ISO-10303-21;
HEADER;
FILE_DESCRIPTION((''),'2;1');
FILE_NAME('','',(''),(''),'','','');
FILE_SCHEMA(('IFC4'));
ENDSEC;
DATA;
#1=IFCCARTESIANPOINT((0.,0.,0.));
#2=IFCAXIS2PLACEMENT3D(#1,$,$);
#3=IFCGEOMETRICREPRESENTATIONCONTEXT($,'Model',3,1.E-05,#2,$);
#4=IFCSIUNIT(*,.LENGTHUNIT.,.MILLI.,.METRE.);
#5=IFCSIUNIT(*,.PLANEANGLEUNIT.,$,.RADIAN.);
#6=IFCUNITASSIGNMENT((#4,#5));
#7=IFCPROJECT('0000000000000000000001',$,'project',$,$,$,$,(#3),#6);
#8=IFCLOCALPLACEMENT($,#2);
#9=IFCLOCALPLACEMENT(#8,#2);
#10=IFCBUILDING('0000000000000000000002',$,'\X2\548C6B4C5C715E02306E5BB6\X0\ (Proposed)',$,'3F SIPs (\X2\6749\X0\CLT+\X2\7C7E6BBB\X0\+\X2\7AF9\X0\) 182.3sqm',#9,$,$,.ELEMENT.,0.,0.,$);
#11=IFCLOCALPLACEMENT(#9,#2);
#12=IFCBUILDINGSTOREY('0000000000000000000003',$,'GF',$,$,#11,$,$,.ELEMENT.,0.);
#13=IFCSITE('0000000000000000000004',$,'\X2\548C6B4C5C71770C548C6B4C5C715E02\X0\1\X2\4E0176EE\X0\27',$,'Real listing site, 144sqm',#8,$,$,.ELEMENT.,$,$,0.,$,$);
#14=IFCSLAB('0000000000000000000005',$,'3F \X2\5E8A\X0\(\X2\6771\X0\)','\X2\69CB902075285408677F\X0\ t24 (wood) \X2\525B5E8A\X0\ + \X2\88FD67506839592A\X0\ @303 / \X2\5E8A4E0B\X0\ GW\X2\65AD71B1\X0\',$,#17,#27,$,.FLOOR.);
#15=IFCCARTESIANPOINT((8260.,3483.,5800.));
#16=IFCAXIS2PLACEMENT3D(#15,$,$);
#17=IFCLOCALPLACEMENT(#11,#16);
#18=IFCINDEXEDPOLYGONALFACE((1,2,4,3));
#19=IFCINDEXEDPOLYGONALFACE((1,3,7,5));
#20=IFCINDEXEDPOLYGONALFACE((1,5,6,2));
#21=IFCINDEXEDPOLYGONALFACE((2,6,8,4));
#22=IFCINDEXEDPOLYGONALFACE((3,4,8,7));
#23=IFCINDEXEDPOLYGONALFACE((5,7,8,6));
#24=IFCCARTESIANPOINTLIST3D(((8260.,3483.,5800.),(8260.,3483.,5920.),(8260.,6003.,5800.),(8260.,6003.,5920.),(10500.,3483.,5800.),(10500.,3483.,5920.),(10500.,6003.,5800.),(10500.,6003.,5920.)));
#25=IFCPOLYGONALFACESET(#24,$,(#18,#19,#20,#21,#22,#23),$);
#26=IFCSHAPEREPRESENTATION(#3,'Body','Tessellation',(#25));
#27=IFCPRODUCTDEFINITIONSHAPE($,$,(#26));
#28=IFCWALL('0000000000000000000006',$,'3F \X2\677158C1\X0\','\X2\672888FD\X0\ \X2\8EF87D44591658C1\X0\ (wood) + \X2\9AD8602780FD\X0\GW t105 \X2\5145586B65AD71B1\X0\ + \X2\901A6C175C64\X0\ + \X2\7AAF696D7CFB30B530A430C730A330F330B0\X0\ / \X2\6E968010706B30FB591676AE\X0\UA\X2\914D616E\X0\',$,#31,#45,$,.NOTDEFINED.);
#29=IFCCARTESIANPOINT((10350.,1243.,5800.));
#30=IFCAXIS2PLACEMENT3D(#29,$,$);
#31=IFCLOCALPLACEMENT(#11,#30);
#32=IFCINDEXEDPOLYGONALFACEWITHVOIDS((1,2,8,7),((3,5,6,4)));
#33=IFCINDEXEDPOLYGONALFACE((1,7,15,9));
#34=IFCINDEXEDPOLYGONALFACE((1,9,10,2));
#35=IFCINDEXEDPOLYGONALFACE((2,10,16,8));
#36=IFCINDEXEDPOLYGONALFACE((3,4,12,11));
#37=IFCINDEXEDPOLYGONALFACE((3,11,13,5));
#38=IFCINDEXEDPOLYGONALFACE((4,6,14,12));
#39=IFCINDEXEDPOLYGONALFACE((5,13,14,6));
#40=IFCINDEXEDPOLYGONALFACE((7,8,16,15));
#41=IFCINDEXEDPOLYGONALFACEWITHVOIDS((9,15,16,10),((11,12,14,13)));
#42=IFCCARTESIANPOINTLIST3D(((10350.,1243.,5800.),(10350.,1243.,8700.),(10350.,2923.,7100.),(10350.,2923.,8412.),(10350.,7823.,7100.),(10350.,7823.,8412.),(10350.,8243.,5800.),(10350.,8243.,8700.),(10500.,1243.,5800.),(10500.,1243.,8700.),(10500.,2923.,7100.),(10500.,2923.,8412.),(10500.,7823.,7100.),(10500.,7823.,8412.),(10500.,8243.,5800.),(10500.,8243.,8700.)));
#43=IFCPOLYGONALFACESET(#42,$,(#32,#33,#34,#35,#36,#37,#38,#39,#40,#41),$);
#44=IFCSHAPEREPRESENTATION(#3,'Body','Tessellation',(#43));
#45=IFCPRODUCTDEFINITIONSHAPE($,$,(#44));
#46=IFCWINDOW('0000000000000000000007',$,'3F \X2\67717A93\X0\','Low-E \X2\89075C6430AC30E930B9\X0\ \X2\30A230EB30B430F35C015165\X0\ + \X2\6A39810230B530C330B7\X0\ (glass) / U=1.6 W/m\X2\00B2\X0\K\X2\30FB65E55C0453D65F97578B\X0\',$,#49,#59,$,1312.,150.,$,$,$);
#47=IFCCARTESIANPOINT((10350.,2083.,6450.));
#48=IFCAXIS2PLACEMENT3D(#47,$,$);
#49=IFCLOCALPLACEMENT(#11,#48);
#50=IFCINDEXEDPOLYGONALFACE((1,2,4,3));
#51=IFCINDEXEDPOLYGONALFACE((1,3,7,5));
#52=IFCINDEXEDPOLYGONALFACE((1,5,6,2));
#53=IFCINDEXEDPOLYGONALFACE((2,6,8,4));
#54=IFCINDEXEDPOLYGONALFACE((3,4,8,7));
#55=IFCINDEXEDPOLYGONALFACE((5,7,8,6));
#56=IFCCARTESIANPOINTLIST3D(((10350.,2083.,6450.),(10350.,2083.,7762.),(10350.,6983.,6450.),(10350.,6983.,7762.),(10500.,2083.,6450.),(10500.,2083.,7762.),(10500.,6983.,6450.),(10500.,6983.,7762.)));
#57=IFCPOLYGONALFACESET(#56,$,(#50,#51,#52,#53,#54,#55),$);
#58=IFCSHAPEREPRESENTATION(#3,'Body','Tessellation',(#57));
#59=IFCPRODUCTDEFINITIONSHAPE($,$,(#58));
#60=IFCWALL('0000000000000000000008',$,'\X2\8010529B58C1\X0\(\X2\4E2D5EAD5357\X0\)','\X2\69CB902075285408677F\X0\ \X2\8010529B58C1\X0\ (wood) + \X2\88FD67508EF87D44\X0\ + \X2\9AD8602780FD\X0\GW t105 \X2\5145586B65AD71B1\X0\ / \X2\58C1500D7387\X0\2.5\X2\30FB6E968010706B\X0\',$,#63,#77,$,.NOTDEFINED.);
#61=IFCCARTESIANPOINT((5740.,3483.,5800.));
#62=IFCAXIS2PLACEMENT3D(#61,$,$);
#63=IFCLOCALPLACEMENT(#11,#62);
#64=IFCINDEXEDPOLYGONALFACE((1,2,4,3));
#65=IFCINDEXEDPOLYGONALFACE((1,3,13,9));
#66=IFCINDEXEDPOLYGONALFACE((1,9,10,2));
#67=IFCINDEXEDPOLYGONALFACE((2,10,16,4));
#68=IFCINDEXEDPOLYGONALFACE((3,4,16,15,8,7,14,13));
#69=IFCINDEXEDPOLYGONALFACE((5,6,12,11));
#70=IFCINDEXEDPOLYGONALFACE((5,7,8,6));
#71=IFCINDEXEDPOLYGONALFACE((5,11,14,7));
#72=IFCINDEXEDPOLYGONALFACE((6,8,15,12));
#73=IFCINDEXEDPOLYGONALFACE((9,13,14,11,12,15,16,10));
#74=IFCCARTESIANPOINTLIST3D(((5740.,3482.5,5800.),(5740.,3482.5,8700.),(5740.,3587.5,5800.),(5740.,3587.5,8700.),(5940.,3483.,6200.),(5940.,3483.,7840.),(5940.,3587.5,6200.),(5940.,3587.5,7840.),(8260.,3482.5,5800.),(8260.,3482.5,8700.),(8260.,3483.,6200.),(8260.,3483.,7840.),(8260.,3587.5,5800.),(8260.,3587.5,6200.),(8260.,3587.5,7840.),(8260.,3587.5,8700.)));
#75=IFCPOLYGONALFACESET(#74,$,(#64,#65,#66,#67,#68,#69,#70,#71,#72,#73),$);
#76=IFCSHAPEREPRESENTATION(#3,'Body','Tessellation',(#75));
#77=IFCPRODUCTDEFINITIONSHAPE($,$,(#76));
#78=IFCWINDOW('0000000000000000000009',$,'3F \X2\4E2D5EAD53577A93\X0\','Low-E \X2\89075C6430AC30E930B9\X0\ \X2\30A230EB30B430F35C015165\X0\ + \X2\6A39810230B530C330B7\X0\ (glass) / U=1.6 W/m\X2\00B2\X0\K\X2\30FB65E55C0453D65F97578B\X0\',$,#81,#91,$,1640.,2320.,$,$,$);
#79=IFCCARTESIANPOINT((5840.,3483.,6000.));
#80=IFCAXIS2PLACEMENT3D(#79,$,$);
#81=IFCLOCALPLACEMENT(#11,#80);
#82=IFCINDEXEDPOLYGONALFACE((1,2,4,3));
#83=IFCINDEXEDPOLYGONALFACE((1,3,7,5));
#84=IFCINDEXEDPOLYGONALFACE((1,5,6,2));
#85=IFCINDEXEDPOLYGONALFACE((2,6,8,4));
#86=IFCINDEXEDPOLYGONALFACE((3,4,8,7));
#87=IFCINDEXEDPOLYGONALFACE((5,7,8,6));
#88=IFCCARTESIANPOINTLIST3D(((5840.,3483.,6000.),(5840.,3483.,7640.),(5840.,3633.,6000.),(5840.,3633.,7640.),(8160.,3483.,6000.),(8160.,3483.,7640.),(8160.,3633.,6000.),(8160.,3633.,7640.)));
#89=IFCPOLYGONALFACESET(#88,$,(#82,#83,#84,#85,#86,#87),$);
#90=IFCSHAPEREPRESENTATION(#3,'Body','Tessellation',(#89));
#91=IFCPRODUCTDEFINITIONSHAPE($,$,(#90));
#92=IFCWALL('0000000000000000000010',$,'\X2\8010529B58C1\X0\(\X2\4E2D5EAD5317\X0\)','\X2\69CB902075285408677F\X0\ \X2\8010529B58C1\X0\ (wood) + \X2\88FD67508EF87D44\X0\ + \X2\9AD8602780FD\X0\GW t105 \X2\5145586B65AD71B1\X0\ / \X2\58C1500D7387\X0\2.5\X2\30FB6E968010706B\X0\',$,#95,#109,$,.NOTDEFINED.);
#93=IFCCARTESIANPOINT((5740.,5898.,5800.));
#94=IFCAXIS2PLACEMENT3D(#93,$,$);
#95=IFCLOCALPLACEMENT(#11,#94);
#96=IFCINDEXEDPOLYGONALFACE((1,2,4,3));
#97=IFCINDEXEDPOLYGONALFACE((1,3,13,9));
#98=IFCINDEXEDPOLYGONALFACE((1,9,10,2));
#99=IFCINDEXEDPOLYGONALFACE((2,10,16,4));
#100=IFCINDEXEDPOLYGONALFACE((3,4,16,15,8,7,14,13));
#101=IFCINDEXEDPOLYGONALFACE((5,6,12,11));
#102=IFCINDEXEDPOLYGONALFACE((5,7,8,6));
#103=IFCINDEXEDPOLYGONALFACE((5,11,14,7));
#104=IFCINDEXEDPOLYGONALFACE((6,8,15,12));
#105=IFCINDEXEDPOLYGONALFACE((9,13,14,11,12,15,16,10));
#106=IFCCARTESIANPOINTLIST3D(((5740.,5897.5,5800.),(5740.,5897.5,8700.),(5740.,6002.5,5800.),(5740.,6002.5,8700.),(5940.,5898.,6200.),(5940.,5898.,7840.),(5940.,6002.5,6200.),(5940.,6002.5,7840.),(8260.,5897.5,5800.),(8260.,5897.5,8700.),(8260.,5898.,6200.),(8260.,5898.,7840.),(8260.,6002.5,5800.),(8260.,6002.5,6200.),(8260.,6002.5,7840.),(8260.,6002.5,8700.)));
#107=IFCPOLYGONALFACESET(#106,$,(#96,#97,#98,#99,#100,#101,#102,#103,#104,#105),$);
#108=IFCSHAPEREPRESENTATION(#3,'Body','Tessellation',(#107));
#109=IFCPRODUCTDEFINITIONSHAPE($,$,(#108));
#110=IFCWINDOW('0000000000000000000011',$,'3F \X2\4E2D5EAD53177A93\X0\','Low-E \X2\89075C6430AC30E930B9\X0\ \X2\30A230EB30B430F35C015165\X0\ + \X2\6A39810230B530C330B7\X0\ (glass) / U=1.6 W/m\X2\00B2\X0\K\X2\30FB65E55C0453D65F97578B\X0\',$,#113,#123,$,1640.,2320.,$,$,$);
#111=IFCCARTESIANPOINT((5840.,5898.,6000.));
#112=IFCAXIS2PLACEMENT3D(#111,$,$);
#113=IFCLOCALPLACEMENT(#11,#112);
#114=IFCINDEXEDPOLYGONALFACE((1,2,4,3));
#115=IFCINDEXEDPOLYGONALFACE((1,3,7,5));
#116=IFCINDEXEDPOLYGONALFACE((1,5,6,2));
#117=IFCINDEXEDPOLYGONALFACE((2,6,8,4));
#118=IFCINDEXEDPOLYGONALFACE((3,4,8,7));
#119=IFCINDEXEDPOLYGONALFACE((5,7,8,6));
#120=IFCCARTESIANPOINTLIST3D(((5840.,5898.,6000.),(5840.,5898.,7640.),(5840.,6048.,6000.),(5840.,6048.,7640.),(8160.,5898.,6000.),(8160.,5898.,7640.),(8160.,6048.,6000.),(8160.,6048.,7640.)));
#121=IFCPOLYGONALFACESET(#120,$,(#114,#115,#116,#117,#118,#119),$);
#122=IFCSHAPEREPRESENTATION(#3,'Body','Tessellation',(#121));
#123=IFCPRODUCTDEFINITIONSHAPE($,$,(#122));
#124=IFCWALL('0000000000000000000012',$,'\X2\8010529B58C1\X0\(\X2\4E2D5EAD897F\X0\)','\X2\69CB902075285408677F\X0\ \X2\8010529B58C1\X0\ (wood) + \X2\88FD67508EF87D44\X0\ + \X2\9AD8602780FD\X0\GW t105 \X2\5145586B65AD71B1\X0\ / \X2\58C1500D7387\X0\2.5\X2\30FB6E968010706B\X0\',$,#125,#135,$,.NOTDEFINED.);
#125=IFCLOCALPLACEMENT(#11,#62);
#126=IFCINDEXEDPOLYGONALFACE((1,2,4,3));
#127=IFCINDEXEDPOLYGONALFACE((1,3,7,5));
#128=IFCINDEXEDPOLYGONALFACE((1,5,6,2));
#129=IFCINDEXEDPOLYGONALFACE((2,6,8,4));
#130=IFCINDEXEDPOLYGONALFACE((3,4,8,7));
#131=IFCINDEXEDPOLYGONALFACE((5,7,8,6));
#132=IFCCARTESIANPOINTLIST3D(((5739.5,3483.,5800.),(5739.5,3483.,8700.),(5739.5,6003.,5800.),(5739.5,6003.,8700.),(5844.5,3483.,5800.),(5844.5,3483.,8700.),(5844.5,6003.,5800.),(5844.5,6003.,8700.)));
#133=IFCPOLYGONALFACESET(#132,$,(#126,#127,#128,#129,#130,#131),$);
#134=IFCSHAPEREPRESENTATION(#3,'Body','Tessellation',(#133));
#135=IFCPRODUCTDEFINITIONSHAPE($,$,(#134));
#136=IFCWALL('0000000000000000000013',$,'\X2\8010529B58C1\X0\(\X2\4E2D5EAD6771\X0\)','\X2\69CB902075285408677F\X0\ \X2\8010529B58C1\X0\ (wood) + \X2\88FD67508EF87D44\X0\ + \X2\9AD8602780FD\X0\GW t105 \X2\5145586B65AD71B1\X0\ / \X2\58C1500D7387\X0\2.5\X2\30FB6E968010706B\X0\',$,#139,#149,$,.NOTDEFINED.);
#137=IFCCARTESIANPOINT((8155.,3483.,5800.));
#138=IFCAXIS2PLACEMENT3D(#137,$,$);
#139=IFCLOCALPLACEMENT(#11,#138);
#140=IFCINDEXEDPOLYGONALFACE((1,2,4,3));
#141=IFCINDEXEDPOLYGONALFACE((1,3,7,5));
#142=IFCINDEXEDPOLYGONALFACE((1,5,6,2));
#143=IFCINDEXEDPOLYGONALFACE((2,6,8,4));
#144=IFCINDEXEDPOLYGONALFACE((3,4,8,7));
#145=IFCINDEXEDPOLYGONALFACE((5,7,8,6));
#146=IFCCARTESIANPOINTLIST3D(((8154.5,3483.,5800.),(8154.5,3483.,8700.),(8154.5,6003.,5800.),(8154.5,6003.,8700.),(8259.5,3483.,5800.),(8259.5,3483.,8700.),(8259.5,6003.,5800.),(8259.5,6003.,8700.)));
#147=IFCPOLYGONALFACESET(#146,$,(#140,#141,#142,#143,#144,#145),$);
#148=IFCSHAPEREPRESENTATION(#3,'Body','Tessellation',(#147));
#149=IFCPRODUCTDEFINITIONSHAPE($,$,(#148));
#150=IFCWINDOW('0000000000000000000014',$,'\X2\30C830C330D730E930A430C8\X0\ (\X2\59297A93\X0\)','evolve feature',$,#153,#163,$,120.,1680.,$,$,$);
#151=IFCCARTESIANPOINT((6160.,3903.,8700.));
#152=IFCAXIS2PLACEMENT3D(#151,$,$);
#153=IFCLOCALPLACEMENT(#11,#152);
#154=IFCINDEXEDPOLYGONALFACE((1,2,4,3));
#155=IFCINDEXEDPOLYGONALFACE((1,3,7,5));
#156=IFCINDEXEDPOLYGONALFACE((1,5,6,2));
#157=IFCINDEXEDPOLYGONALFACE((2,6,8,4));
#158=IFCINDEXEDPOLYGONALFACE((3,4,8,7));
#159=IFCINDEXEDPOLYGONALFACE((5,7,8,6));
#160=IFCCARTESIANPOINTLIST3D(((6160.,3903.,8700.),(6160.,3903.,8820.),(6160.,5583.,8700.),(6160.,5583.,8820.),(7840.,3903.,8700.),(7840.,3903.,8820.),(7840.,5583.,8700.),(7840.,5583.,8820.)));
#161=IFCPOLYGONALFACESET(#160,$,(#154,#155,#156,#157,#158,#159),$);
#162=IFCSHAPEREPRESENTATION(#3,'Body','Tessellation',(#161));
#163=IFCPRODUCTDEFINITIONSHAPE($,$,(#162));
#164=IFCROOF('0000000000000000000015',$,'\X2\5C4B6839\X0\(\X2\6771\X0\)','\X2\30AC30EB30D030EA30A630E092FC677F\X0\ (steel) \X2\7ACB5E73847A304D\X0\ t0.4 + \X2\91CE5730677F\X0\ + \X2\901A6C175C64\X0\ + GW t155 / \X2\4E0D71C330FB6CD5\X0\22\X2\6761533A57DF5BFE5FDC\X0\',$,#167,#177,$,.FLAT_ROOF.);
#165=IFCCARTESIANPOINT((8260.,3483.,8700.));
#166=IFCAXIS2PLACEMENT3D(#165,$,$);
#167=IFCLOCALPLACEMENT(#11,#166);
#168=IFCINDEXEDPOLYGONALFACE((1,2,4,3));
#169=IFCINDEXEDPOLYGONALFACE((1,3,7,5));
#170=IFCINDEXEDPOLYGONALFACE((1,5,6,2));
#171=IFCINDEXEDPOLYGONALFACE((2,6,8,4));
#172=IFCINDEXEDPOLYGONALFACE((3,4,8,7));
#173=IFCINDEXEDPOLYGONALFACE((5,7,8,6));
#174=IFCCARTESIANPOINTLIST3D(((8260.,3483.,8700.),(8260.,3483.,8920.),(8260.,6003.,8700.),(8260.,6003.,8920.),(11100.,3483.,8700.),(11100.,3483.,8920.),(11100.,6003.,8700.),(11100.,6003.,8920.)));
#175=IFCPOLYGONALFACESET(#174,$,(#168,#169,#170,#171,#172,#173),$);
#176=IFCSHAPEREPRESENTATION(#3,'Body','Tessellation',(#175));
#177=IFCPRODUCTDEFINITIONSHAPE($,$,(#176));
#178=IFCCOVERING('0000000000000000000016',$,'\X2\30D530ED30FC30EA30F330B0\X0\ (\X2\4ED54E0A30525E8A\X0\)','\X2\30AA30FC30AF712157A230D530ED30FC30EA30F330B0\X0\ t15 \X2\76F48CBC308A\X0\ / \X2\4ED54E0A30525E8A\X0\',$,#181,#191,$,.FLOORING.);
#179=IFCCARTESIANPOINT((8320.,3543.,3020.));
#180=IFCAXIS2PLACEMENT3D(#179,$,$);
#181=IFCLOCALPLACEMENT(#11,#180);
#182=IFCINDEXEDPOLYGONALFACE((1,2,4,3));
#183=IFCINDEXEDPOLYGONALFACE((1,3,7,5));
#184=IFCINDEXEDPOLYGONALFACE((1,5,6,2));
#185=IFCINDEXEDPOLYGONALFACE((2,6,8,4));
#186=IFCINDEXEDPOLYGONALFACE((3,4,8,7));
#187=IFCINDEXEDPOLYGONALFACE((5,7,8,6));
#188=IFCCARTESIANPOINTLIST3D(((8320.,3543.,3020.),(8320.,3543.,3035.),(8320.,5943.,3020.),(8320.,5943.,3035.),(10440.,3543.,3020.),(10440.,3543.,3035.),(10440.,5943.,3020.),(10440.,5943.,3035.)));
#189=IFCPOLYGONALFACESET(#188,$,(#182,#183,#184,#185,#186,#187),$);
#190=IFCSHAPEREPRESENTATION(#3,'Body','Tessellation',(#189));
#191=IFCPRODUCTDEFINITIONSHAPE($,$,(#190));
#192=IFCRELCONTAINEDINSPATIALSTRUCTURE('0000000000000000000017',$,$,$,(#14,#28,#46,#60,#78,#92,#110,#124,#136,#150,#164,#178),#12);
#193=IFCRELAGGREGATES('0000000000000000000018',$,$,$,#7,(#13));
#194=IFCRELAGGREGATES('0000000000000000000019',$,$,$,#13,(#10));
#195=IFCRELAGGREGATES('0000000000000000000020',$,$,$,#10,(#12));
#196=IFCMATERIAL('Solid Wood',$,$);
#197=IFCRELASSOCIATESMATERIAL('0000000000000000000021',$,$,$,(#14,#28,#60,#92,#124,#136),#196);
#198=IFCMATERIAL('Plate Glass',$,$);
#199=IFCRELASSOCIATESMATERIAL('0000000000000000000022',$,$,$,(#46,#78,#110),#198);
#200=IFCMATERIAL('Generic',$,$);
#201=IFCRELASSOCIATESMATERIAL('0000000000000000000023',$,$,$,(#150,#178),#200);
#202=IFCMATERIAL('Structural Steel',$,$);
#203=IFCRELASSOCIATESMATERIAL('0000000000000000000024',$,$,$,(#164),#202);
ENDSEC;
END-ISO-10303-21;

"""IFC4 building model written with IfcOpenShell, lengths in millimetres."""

from ifc_helpers import new_model, si_unit, frame, frame_2d, origin, place, context, project, spatial, rectangle, extrude, material, element, fill, save


model = new_model("IFC4")

# Units and contexts
model_context = context("Model", 3, precision=1e-05, world=origin())
ifc_project = project(units=[si_unit("LENGTHUNIT", "METRE", prefix="MILLI"), si_unit("PLANEANGLEUNIT", "RADIAN")], contexts=[model_context])

# Site, building, storey
site_placement = place(None, origin())
site = spatial("IfcSite", under=ifc_project, at=site_placement, Name="和歌山県和歌山市1丁目27", ObjectType="Real listing site, 144sqm", CompositionType="ELEMENT", RefElevation=0.0)
building_placement = place(site_placement, origin())
building = spatial("IfcBuilding", under=site, at=building_placement, Name="和歌山市の家 (Proposed)", ObjectType="3F SIPs (杉CLT+籾殻+竹) 182.3sqm", CompositionType="ELEMENT", ElevationOfRefHeight=0.0, ElevationOfTerrain=0.0)
storey_placement = place(building_placement, origin())
storey = spatial("IfcBuildingStorey", under=building, at=storey_placement, Name="GF", CompositionType="ELEMENT", Elevation=0.0)

# Slab
ifc_material_1 = material(Name="Solid Wood")
slab_placement = place(storey_placement, frame((8260.0, 3483.0, 5800.0)))
element("IfcSlab", 1, at=slab_placement, inside=storey, material=ifc_material_1, Name="3F 床(東)", Description="構造用合板 t24 (wood) 剛床 + 製材根太 @303 / 床下 GW断熱", PredefinedType="FLOOR", context=model_context, shape_type="SweptSolid", body=[
    extrude(rectangle(XDim=2240.0, YDim=2520.0, at=frame_2d((1120.0, 1260.0))), frame((8260.0, 3483.0, 5800.0)), (0.0, 0.0, 1.0), 120.0),
])

# Walls, openings, windows
wall_1_placement = place(storey_placement, frame((10350.0, 1243.0, 5800.0)))
wall_1 = element("IfcWall", 2, at=wall_1_placement, inside=storey, material=ifc_material_1, Name="3F 東壁", Description="木製 軸組外壁 (wood) + 高性能GW t105 充填断熱 + 通気層 + 窯業系サイディング / 準耐火・外皮UA配慮", PredefinedType="NOTDEFINED", context=model_context, shape_type="SweptSolid", body=[
    extrude(rectangle(XDim=150.0, YDim=7000.0, at=frame_2d((75.0, 3500.0))), frame((10350.0, 1243.0, 5800.0)), (0.0, 0.0, 1.0), 2900.0),
])
opening_1_placement = place(storey_placement, frame((10350.0, 2083.0, 6450.0)))
opening_1 = element("IfcOpeningElement", 3, at=opening_1_placement, cuts=wall_1, PredefinedType="NOTDEFINED", context=model_context, shape_type="SweptSolid", body=[
    extrude(rectangle(XDim=150.0, YDim=4900.0, at=frame_2d((75.0, 2450.0))), frame((10350.0, 2083.0, 6450.0)), (0.0, 0.0, 1.0), 1312.0),
])
ifc_material_2 = material(Name="Plate Glass")
window_1_placement = place(storey_placement, frame((10350.0, 2083.0, 6450.0)))
window_1 = element("IfcWindow", 4, at=window_1_placement, inside=storey, material=ifc_material_2, Name="3F 東窓", Description="Low-E 複層ガラス アルゴン封入 + 樹脂サッシ (glass) / U=1.6 W/m²K・日射取得型", OverallHeight=1312.0, OverallWidth=150.0, context=model_context, shape_type="SweptSolid", body=[
    extrude(rectangle(XDim=150.0, YDim=4900.0, at=frame_2d((75.0, 2450.0))), frame((10350.0, 2083.0, 6450.0)), (0.0, 0.0, 1.0), 1312.0),
])
fill(opening_1, window_1)
wall_2_placement = place(storey_placement, frame((5740.0, 3483.0, 5800.0)))
wall_2 = element("IfcWall", 5, at=wall_2_placement, inside=storey, material=ifc_material_1, Name="耐力壁(中庭南)", Description="構造用合板 耐力壁 (wood) + 製材軸組 + 高性能GW t105 充填断熱 / 壁倍率2.5・準耐火", PredefinedType="NOTDEFINED", context=model_context, shape_type="SweptSolid", body=[
    extrude(rectangle(XDim=2520.0, YDim=105.0, at=frame_2d((1260.0, 52.0))), frame((5740.0, 3483.0, 5800.0)), (0.0, 0.0, 1.0), 2900.0),
])
opening_2_placement = place(storey_placement, frame((5840.0, 3483.0, 6000.0)))
opening_2 = element("IfcOpeningElement", 6, at=opening_2_placement, cuts=wall_2, PredefinedType="NOTDEFINED", context=model_context, shape_type="SweptSolid", body=[
    extrude(rectangle(XDim=2320.0, YDim=150.0, at=frame_2d((1160.0, 75.0))), frame((5840.0, 3483.0, 6000.0)), (0.0, 0.0, 1.0), 1640.0),
])
window_2_placement = place(storey_placement, frame((5840.0, 3483.0, 6000.0)))
window_2 = element("IfcWindow", 7, at=window_2_placement, inside=storey, material=ifc_material_2, Name="3F 中庭南窓", Description="Low-E 複層ガラス アルゴン封入 + 樹脂サッシ (glass) / U=1.6 W/m²K・日射取得型", OverallHeight=1640.0, OverallWidth=2320.0, context=model_context, shape_type="SweptSolid", body=[
    extrude(rectangle(XDim=2320.0, YDim=150.0, at=frame_2d((1160.0, 75.0))), frame((5840.0, 3483.0, 6000.0)), (0.0, 0.0, 1.0), 1640.0),
])
fill(opening_2, window_2)
wall_3_placement = place(storey_placement, frame((5740.0, 5898.0, 5800.0)))
wall_3 = element("IfcWall", 8, at=wall_3_placement, inside=storey, material=ifc_material_1, Name="耐力壁(中庭北)", Description="構造用合板 耐力壁 (wood) + 製材軸組 + 高性能GW t105 充填断熱 / 壁倍率2.5・準耐火", PredefinedType="NOTDEFINED", context=model_context, shape_type="SweptSolid", body=[
    extrude(rectangle(XDim=2520.0, YDim=105.0, at=frame_2d((1260.0, 52.0))), frame((5740.0, 5898.0, 5800.0)), (0.0, 0.0, 1.0), 2900.0),
])
opening_3_placement = place(storey_placement, frame((5840.0, 5898.0, 6000.0)))
opening_3 = element("IfcOpeningElement", 9, at=opening_3_placement, cuts=wall_3, PredefinedType="NOTDEFINED", context=model_context, shape_type="SweptSolid", body=[
    extrude(rectangle(XDim=2320.0, YDim=150.0, at=frame_2d((1160.0, 75.0))), frame((5840.0, 5898.0, 6000.0)), (0.0, 0.0, 1.0), 1640.0),
])
window_3_placement = place(storey_placement, frame((5840.0, 5898.0, 6000.0)))
window_3 = element("IfcWindow", 10, at=window_3_placement, inside=storey, material=ifc_material_2, Name="3F 中庭北窓", Description="Low-E 複層ガラス アルゴン封入 + 樹脂サッシ (glass) / U=1.6 W/m²K・日射取得型", OverallHeight=1640.0, OverallWidth=2320.0, context=model_context, shape_type="SweptSolid", body=[
    extrude(rectangle(XDim=2320.0, YDim=150.0, at=frame_2d((1160.0, 75.0))), frame((5840.0, 5898.0, 6000.0)), (0.0, 0.0, 1.0), 1640.0),
])
fill(opening_3, window_3)

# Walls
wall_4_placement = place(storey_placement, frame((5740.0, 3483.0, 5800.0)))
element("IfcWall", 11, at=wall_4_placement, inside=storey, material=ifc_material_1, Name="耐力壁(中庭西)", Description="構造用合板 耐力壁 (wood) + 製材軸組 + 高性能GW t105 充填断熱 / 壁倍率2.5・準耐火", PredefinedType="NOTDEFINED", context=model_context, shape_type="SweptSolid", body=[
    extrude(rectangle(XDim=105.0, YDim=2520.0, at=frame_2d((52.0, 1260.0))), frame((5740.0, 3483.0, 5800.0)), (0.0, 0.0, 1.0), 2900.0),
])
wall_5_placement = place(storey_placement, frame((8155.0, 3483.0, 5800.0)))
element("IfcWall", 12, at=wall_5_placement, inside=storey, material=ifc_material_1, Name="耐力壁(中庭東)", Description="構造用合板 耐力壁 (wood) + 製材軸組 + 高性能GW t105 充填断熱 / 壁倍率2.5・準耐火", PredefinedType="NOTDEFINED", context=model_context, shape_type="SweptSolid", body=[
    extrude(rectangle(XDim=105.0, YDim=2520.0, at=frame_2d((52.0, 1260.0))), frame((8155.0, 3483.0, 5800.0)), (0.0, 0.0, 1.0), 2900.0),
])

# Window
ifc_material_3 = material(Name="Generic")
window_4_placement = place(storey_placement, frame((6160.0, 3903.0, 8700.0)))
element("IfcWindow", 13, at=window_4_placement, inside=storey, material=ifc_material_3, Name="トップライト (天窓)", Description="evolve feature", OverallHeight=120.0, OverallWidth=1680.0, context=model_context, shape_type="SweptSolid", body=[
    extrude(rectangle(XDim=1680.0, YDim=1680.0, at=frame_2d((840.0, 840.0))), frame((6160.0, 3903.0, 8700.0)), (0.0, 0.0, 1.0), 120.0),
])

# Roof
ifc_material_4 = material(Name="Structural Steel")
for number, where, name in (
    (14, (8260.0, 3483.0, 8700.0), "屋根(東)"),
):
    element("IfcRoof", number, at=place(storey_placement, frame(where)), inside=storey, material=ifc_material_4, Name=name, Description="ガルバリウム鋼板 (steel) 立平葺き t0.4 + 野地板 + 通気層 + GW t155 / 不燃・法22条区域対応", PredefinedType="FLAT_ROOF", context=model_context, shape_type="SweptSolid", body=[
        extrude(rectangle(XDim=2840.0, YDim=2520.0, at=frame_2d((1420.0, 1260.0))), frame((8260.0, 3483.0, 8700.0)), (0.0, 0.0, 1.0), 220.0),
    ])

# Covering
covering_1_placement = place(storey_placement, frame((8320.0, 3543.0, 3020.0)))
element("IfcCovering", 15, at=covering_1_placement, inside=storey, material=ifc_material_3, Name="フローリング (仕上げ床)", Description="オーク無垢フローリング t15 直貼り / 仕上げ床", PredefinedType="FLOORING", context=model_context, shape_type="SweptSolid", body=[
    extrude(rectangle(XDim=2120.0, YDim=2400.0, at=frame_2d((1060.0, 1200.0))), frame((8320.0, 3543.0, 3020.0)), (0.0, 0.0, 1.0), 15.0),
])

save(model, "model.ifc")
